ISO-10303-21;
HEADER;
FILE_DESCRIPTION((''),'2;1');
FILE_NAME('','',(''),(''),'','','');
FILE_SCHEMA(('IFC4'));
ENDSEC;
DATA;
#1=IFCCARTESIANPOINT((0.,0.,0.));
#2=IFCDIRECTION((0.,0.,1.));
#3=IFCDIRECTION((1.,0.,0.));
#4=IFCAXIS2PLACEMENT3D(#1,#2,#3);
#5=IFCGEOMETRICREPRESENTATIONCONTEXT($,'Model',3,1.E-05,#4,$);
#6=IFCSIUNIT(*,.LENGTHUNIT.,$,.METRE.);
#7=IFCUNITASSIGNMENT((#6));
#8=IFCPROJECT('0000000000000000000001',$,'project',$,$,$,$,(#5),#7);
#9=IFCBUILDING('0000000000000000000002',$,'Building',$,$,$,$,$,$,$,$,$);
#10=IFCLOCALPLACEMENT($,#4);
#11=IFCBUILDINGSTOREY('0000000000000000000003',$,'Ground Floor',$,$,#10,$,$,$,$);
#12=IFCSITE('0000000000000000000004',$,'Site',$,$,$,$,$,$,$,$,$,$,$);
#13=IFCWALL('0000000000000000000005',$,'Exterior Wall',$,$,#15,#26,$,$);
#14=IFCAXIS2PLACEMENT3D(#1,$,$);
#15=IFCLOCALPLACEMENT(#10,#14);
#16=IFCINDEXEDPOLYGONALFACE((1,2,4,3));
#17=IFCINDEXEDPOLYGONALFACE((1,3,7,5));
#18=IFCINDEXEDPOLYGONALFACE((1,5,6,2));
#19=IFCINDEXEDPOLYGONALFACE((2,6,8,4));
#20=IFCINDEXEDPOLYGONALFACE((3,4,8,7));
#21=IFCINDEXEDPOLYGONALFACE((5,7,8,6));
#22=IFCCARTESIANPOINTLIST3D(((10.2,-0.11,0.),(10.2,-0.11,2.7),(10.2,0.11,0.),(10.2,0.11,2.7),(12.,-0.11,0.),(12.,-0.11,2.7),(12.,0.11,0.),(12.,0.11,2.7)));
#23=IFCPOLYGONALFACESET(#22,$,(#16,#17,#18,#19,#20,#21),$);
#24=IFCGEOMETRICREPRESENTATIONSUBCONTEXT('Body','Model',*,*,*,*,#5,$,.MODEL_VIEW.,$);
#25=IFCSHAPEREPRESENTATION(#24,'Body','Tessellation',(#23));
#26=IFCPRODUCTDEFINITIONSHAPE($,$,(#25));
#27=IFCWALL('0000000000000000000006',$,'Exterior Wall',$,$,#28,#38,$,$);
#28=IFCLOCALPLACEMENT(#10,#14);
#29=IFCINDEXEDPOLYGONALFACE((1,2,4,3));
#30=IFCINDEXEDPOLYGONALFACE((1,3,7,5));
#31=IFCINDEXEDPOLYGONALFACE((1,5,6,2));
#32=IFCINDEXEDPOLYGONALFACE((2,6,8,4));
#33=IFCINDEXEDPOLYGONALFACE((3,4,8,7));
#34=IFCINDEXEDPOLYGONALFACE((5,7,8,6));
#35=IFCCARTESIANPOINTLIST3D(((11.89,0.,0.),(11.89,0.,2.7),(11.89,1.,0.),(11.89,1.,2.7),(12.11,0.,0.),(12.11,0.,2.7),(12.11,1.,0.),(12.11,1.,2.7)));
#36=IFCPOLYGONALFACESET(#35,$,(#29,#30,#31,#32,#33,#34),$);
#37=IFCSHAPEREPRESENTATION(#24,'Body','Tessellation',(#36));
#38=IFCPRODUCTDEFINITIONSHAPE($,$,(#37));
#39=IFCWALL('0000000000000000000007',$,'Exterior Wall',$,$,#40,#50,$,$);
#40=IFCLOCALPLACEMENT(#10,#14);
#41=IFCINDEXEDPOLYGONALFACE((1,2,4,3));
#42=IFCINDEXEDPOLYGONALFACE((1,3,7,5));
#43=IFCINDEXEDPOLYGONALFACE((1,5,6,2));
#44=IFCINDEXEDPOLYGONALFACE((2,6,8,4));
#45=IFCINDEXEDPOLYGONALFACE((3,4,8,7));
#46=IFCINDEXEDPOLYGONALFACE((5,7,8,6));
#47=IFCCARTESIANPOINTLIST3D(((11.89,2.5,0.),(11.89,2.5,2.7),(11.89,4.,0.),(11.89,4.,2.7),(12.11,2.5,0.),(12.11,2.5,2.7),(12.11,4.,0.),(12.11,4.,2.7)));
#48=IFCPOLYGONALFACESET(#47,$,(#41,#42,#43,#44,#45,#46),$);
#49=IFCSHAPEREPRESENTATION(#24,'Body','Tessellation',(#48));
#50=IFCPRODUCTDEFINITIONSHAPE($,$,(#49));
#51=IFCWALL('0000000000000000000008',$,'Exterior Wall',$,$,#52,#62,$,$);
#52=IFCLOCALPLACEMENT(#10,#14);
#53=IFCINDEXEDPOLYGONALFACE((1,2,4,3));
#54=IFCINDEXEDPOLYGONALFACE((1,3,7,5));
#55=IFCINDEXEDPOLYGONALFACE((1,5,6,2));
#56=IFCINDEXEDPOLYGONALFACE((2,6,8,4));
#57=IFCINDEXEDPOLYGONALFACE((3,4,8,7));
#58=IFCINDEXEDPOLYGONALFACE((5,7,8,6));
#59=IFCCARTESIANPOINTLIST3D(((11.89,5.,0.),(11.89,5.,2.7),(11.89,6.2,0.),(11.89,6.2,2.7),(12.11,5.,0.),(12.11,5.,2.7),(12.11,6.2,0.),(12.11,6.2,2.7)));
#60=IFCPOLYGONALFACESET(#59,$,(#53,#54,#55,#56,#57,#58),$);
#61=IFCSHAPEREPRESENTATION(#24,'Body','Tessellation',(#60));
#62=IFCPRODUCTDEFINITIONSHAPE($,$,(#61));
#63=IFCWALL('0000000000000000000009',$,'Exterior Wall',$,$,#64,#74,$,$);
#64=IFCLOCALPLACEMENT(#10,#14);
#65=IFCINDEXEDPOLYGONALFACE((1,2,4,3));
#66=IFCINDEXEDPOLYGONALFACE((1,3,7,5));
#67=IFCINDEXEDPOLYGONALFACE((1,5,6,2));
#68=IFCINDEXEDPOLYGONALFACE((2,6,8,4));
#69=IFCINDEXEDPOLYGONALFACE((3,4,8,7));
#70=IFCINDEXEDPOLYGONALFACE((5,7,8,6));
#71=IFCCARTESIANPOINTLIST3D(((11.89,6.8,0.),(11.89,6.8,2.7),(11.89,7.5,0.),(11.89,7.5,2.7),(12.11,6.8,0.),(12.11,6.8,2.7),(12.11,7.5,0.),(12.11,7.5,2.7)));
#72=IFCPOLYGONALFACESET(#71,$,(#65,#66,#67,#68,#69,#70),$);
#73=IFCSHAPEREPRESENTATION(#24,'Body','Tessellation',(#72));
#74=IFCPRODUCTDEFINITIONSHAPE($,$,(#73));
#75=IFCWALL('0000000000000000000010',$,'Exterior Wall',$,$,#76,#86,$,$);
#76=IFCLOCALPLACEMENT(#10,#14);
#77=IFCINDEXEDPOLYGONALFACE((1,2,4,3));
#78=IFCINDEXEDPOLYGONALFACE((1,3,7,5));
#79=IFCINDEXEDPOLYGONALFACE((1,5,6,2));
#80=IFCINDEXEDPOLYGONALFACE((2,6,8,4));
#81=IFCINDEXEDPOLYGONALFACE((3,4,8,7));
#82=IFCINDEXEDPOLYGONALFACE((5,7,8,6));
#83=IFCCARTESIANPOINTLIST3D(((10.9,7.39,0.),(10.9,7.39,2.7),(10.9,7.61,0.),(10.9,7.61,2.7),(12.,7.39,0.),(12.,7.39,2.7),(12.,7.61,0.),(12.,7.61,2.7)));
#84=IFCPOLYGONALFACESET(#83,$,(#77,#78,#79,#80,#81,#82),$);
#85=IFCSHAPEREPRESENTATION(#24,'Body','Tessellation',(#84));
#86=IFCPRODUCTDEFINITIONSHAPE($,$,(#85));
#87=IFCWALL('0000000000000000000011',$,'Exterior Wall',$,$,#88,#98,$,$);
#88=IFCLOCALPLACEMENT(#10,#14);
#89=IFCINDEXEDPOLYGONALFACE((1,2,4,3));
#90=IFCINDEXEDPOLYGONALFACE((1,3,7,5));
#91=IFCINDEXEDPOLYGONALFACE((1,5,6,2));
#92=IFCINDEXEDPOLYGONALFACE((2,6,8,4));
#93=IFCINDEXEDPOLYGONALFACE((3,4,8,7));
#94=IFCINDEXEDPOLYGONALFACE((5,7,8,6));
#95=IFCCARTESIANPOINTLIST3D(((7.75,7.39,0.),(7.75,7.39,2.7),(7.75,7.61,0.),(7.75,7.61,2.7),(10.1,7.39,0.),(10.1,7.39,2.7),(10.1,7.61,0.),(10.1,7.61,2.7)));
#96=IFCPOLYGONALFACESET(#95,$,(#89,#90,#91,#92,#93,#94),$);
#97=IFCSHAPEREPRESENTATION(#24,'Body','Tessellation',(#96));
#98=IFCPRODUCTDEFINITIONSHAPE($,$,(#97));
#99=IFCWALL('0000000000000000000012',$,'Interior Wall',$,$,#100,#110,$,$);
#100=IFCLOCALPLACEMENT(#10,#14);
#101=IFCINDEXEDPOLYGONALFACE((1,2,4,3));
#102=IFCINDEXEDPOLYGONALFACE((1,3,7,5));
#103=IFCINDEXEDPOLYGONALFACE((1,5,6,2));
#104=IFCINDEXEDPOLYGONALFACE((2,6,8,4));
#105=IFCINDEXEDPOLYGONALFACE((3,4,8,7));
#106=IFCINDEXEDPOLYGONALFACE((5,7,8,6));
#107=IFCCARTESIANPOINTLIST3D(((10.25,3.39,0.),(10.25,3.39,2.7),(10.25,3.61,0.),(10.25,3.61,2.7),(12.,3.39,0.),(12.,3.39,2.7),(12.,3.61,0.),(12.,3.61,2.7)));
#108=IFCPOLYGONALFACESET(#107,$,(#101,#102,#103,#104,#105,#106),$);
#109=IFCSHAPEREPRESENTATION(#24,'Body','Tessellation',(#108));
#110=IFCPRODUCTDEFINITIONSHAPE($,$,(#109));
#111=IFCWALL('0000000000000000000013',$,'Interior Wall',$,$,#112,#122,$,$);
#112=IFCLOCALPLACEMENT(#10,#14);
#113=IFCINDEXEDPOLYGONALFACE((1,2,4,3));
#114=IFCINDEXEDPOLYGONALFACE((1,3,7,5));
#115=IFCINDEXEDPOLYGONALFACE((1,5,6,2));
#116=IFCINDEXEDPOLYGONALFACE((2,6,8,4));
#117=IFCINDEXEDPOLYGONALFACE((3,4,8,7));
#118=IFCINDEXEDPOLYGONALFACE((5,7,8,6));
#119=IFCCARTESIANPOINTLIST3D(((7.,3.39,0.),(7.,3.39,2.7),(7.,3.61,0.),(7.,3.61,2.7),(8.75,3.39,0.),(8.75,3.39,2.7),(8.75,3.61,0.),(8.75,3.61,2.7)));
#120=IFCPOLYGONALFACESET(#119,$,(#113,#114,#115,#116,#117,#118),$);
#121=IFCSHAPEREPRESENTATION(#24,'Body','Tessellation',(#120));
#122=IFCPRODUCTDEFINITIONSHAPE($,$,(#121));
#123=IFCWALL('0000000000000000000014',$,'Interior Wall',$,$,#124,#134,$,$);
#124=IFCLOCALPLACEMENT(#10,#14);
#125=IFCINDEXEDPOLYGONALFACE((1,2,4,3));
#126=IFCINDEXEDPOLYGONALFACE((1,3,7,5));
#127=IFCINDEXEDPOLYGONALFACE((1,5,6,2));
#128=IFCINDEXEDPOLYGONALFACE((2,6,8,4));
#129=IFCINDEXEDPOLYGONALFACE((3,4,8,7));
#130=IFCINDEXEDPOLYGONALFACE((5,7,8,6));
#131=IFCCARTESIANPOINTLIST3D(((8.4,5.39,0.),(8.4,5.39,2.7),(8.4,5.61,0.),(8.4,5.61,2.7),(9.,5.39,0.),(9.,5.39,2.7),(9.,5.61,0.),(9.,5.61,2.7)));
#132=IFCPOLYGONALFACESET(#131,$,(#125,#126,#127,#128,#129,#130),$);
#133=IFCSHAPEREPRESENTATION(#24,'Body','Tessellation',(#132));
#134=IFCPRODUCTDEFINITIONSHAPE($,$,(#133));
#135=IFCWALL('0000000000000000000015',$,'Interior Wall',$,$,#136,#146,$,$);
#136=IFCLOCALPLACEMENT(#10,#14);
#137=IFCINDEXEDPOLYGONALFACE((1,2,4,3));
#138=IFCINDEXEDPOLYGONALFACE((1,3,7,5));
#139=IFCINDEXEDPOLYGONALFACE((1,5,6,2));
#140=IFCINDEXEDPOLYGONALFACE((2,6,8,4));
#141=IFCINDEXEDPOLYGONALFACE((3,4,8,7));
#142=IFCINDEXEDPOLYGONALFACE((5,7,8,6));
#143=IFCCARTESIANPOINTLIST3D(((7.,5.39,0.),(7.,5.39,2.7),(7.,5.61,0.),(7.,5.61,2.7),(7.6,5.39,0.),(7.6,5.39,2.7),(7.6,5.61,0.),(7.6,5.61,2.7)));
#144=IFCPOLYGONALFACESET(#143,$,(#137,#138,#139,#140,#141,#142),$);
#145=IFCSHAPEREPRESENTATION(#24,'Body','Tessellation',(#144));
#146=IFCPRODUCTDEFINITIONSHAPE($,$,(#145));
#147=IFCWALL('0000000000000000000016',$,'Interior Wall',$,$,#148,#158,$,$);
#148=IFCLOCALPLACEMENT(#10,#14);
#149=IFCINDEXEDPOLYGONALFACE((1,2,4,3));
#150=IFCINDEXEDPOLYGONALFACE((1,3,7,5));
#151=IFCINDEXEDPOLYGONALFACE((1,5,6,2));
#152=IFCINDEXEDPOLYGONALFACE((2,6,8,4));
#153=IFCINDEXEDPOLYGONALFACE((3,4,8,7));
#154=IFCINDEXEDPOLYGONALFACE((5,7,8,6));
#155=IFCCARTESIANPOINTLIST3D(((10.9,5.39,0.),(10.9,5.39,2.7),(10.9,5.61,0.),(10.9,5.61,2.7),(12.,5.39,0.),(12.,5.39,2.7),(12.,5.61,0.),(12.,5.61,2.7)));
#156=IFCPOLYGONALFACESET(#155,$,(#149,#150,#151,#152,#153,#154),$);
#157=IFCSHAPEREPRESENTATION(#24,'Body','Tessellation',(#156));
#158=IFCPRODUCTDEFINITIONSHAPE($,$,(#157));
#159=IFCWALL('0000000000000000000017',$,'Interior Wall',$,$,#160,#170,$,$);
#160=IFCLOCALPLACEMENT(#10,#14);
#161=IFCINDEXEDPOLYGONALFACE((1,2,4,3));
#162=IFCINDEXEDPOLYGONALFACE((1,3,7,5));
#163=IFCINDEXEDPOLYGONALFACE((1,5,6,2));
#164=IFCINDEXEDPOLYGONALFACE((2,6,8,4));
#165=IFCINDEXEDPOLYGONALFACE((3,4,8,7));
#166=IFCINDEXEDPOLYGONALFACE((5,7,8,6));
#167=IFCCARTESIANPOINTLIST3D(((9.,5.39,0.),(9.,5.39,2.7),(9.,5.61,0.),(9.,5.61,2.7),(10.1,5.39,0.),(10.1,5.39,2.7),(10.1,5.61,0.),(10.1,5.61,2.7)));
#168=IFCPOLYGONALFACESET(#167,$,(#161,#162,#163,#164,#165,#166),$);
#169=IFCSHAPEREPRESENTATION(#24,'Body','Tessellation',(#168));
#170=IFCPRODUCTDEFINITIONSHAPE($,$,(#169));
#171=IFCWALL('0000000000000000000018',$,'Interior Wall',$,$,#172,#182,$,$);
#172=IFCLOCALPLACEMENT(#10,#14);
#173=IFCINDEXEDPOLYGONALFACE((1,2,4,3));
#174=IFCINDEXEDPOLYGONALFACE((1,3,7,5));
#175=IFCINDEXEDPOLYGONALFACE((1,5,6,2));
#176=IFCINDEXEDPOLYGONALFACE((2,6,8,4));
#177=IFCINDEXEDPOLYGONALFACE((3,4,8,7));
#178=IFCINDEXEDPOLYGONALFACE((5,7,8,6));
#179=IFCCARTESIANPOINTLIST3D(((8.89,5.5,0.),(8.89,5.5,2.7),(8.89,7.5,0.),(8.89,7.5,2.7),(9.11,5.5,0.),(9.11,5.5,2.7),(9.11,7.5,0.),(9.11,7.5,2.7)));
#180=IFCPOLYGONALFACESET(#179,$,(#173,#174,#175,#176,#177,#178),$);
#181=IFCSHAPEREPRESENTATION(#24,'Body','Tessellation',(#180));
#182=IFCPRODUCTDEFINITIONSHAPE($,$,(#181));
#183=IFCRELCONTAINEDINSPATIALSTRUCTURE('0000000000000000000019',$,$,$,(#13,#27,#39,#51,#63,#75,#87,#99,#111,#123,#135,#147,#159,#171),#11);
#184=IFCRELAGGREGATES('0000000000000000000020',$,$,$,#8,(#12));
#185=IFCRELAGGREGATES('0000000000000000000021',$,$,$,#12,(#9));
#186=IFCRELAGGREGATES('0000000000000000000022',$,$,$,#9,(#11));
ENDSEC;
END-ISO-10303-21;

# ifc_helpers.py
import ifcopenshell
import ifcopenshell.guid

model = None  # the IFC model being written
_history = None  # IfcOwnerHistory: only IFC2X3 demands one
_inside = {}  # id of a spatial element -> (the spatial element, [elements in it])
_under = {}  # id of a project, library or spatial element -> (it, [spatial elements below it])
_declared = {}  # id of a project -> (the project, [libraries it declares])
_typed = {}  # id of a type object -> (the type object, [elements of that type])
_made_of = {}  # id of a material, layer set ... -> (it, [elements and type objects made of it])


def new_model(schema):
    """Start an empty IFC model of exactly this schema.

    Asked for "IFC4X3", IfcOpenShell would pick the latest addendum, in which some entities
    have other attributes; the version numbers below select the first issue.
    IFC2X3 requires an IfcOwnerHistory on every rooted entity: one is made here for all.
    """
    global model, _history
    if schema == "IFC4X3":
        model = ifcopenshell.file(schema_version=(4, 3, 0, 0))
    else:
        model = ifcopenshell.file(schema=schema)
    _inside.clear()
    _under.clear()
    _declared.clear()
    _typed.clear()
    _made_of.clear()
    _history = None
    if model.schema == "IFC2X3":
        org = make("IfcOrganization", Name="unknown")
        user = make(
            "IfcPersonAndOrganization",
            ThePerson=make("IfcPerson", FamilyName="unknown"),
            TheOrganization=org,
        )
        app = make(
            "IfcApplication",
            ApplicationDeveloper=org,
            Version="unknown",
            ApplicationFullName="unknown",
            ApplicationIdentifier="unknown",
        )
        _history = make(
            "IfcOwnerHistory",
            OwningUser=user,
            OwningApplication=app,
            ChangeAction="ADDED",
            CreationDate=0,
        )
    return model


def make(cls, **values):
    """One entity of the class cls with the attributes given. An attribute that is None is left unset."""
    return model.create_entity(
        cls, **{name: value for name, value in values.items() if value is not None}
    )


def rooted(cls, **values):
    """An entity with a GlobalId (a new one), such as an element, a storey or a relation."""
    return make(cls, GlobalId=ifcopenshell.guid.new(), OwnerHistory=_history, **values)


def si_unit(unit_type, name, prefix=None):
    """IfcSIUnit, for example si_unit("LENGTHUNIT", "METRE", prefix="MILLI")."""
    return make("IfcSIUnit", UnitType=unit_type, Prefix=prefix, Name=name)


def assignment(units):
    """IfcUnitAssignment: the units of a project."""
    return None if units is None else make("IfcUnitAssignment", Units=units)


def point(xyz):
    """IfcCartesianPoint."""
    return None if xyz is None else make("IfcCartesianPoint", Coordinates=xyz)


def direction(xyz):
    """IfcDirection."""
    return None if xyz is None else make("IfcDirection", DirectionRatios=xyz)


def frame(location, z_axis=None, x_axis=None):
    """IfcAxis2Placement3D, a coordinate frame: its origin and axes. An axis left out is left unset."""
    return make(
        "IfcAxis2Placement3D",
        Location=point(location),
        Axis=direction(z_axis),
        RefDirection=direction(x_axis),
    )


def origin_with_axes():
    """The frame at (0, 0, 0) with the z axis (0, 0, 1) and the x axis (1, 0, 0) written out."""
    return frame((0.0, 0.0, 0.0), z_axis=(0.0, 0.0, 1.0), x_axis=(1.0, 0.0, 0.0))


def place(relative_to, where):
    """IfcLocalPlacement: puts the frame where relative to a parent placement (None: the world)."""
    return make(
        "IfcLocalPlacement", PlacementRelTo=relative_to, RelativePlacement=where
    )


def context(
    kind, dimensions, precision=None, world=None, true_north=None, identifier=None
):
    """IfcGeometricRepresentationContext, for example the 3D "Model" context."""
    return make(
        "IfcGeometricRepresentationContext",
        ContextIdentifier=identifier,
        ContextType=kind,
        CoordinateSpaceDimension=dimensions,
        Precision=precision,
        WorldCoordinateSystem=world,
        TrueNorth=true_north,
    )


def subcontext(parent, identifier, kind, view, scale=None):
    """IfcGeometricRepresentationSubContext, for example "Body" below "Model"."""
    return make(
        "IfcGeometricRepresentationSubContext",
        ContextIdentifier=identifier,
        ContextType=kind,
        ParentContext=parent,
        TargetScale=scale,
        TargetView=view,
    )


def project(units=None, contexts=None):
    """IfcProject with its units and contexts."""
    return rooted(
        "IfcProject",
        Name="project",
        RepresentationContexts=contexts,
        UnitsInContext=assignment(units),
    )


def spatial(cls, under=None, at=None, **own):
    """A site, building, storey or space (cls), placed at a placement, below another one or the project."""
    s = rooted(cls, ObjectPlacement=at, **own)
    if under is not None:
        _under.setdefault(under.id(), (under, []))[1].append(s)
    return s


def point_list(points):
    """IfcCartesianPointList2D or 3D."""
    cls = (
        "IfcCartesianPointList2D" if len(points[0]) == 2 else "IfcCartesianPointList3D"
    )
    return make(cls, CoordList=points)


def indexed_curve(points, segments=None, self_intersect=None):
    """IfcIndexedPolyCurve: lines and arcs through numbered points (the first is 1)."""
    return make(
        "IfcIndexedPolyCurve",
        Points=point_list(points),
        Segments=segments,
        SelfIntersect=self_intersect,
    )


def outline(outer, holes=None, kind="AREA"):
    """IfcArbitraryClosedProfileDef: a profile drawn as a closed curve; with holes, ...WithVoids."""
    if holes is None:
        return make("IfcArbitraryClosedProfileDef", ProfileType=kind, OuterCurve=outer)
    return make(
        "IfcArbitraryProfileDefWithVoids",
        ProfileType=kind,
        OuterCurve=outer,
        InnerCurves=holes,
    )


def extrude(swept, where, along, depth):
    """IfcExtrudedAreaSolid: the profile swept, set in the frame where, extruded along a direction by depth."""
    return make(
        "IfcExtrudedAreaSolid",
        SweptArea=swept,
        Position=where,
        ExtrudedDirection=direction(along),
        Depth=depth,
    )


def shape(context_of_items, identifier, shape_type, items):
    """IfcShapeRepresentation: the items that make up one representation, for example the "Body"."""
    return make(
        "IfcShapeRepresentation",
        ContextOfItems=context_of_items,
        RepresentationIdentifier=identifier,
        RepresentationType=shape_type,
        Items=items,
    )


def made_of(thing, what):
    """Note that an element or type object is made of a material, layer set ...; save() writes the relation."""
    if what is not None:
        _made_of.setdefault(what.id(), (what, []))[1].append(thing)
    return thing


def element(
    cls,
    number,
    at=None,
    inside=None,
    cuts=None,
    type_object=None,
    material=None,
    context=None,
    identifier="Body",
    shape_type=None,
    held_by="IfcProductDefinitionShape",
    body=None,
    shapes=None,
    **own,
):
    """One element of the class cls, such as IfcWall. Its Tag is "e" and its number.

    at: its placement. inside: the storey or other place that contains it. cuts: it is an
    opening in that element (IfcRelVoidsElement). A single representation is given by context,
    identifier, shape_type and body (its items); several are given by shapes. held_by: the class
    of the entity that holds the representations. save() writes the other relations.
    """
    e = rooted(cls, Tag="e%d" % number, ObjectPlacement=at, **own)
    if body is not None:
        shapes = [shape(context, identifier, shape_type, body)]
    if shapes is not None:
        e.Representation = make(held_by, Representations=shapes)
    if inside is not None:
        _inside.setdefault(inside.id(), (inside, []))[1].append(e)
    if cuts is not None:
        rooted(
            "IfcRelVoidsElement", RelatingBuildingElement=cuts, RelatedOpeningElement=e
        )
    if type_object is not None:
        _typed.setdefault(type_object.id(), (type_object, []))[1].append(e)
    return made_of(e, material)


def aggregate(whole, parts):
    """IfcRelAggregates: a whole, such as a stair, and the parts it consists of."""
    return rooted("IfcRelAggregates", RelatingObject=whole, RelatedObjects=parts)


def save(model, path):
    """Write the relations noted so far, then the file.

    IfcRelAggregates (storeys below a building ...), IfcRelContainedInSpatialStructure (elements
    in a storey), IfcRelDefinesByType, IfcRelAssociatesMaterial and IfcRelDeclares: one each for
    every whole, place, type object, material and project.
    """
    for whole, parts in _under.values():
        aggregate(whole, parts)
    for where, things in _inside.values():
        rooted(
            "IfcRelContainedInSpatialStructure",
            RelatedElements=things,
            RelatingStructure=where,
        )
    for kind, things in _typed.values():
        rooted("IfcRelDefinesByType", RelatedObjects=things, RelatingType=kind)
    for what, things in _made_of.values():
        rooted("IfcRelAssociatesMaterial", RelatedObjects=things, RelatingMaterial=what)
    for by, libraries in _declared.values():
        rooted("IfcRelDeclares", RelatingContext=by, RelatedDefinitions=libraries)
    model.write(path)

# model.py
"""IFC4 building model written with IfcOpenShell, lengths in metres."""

from ifc_helpers import new_model, si_unit, frame, origin_with_axes, place, context, subcontext, project, spatial, indexed_curve, outline, extrude, element, save


model = new_model("IFC4")

# Units and contexts
model_context = context("Model", 3, precision=1e-05, world=origin_with_axes())
body_context = subcontext(model_context, "Body", "Model", "MODEL_VIEW")
ifc_project = project(units=[si_unit("LENGTHUNIT", "METRE")], contexts=[model_context])

# Site, building, storey
site = spatial("IfcSite", under=ifc_project, Name="Site")
building = spatial("IfcBuilding", under=site, Name="Building")
storey_placement = place(None, origin_with_axes())
storey = spatial("IfcBuildingStorey", under=building, at=storey_placement, Name="Ground Floor")

# Walls
wall_1_placement = place(storey_placement, frame((10.2, 0.0, 0.0), z_axis=(0.0, 0.0, 1.0), x_axis=(1.0, 0.0, 0.0)))
element("IfcWall", 1, at=wall_1_placement, inside=storey, Name="Exterior Wall", context=body_context, shape_type="SweptSolid", body=[
    extrude(outline(indexed_curve([(0.0, 0.0), (0.0, 0.22), (1.8, 0.22), (1.8, 0.0), (0.0, 0.0)], self_intersect=False)), frame((0.0, -0.11, 0.0), z_axis=(0.0, 0.0, 1.0), x_axis=(1.0, 0.0, 0.0)), (0.0, 0.0, 1.0), 2.7),
])
wall_2_placement = place(storey_placement, frame((12.0, 0.0, 0.0), z_axis=(0.0, 0.0, 1.0), x_axis=(0.0, 1.0, 0.0)))
element("IfcWall", 2, at=wall_2_placement, inside=storey, Name="Exterior Wall", context=body_context, shape_type="SweptSolid", body=[
    extrude(outline(indexed_curve([(0.0, 0.0), (0.0, 0.22), (1.0, 0.22), (1.0, 0.0), (0.0, 0.0)], self_intersect=False)), frame((0.0, -0.11, 0.0), z_axis=(0.0, 0.0, 1.0), x_axis=(1.0, 0.0, 0.0)), (0.0, 0.0, 1.0), 2.7),
])
wall_3_placement = place(storey_placement, frame((12.0, 2.5, 0.0), z_axis=(0.0, 0.0, 1.0), x_axis=(0.0, 1.0, 0.0)))
element("IfcWall", 3, at=wall_3_placement, inside=storey, Name="Exterior Wall", context=body_context, shape_type="SweptSolid", body=[
    extrude(outline(indexed_curve([(0.0, 0.0), (0.0, 0.22), (1.5, 0.22), (1.5, 0.0), (0.0, 0.0)], self_intersect=False)), frame((0.0, -0.11, 0.0), z_axis=(0.0, 0.0, 1.0), x_axis=(1.0, 0.0, 0.0)), (0.0, 0.0, 1.0), 2.7),
])
wall_4_placement = place(storey_placement, frame((12.0, 5.0, 0.0), z_axis=(0.0, 0.0, 1.0), x_axis=(0.0, 1.0, 0.0)))
element("IfcWall", 4, at=wall_4_placement, inside=storey, Name="Exterior Wall", context=body_context, shape_type="SweptSolid", body=[
    extrude(outline(indexed_curve([(0.0, 0.0), (0.0, 0.22), (1.2, 0.22), (1.2, 0.0), (0.0, 0.0)], self_intersect=False)), frame((0.0, -0.11, 0.0), z_axis=(0.0, 0.0, 1.0), x_axis=(1.0, 0.0, 0.0)), (0.0, 0.0, 1.0), 2.7),
])
wall_5_placement = place(storey_placement, frame((12.0, 6.8, 0.0), z_axis=(0.0, 0.0, 1.0), x_axis=(0.0, 1.0, 0.0)))
element("IfcWall", 5, at=wall_5_placement, inside=storey, Name="Exterior Wall", context=body_context, shape_type="SweptSolid", body=[
    extrude(outline(indexed_curve([(0.0, 0.0), (0.0, 0.22), (0.7, 0.22), (0.7, 0.0), (0.0, 0.0)], self_intersect=False)), frame((0.0, -0.11, 0.0), z_axis=(0.0, 0.0, 1.0), x_axis=(1.0, 0.0, 0.0)), (0.0, 0.0, 1.0), 2.7),
])
wall_6_placement = place(storey_placement, frame((12.0, 7.5, 0.0), z_axis=(0.0, 0.0, 1.0), x_axis=(-1.0, 0.0, 0.0)))
element("IfcWall", 6, at=wall_6_placement, inside=storey, Name="Exterior Wall", context=body_context, shape_type="SweptSolid", body=[
    extrude(outline(indexed_curve([(0.0, 0.0), (0.0, 0.22), (1.1, 0.22), (1.1, 0.0), (0.0, 0.0)], self_intersect=False)), frame((0.0, -0.11, 0.0), z_axis=(0.0, 0.0, 1.0), x_axis=(1.0, 0.0, 0.0)), (0.0, 0.0, 1.0), 2.7),
])
wall_7_placement = place(storey_placement, frame((10.1, 7.5, 0.0), z_axis=(0.0, 0.0, 1.0), x_axis=(-1.0, 0.0, 0.0)))
element("IfcWall", 7, at=wall_7_placement, inside=storey, Name="Exterior Wall", context=body_context, shape_type="SweptSolid", body=[
    extrude(outline(indexed_curve([(0.0, 0.0), (0.0, 0.22), (2.35, 0.22), (2.35, 0.0), (0.0, 0.0)], self_intersect=False)), frame((0.0, -0.11, 0.0), z_axis=(0.0, 0.0, 1.0), x_axis=(1.0, 0.0, 0.0)), (0.0, 0.0, 1.0), 2.7),
])
for number, where, z_axis, x_axis, name in (
    (8, (12.0, 3.5, 0.0), (0.0, 0.0, 1.0), (-1.0, 0.0, 0.0), "Interior Wall"),
    (9, (8.75, 3.5, 0.0), (0.0, 0.0, 1.0), (-1.0, 0.0, 0.0), "Interior Wall"),
):
    element("IfcWall", number, at=place(storey_placement, frame(where, z_axis=z_axis, x_axis=x_axis)), inside=storey, Name=name, context=body_context, shape_type="SweptSolid", body=[
        extrude(outline(indexed_curve([(0.0, 0.0), (0.0, 0.22), (1.75, 0.22), (1.75, 0.0), (0.0, 0.0)], self_intersect=False)), frame((0.0, -0.11, 0.0), z_axis=(0.0, 0.0, 1.0), x_axis=(1.0, 0.0, 0.0)), (0.0, 0.0, 1.0), 2.7),
    ])
for number, where, z_axis, x_axis, name in (
    (10, (9.0, 5.5, 0.0), (0.0, 0.0, 1.0), (-1.0, 0.0, 0.0), "Interior Wall"),
    (11, (7.6, 5.5, 0.0), (0.0, 0.0, 1.0), (-1.0, 0.0, 0.0), "Interior Wall"),
):
    element("IfcWall", number, at=place(storey_placement, frame(where, z_axis=z_axis, x_axis=x_axis)), inside=storey, Name=name, context=body_context, shape_type="SweptSolid", body=[
        extrude(outline(indexed_curve([(0.0, 0.0), (0.0, 0.22), (0.6, 0.22), (0.6, 0.0), (0.0, 0.0)], self_intersect=False)), frame((0.0, -0.11, 0.0), z_axis=(0.0, 0.0, 1.0), x_axis=(1.0, 0.0, 0.0)), (0.0, 0.0, 1.0), 2.7),
    ])
for number, where, z_axis, x_axis, name in (
    (12, (12.0, 5.5, 0.0), (0.0, 0.0, 1.0), (-1.0, 0.0, 0.0), "Interior Wall"),
    (13, (10.1, 5.5, 0.0), (0.0, 0.0, 1.0), (-1.0, 0.0, 0.0), "Interior Wall"),
):
    element("IfcWall", number, at=place(storey_placement, frame(where, z_axis=z_axis, x_axis=x_axis)), inside=storey, Name=name, context=body_context, shape_type="SweptSolid", body=[
        extrude(outline(indexed_curve([(0.0, 0.0), (0.0, 0.22), (1.1, 0.22), (1.1, 0.0), (0.0, 0.0)], self_intersect=False)), frame((0.0, -0.11, 0.0), z_axis=(0.0, 0.0, 1.0), x_axis=(1.0, 0.0, 0.0)), (0.0, 0.0, 1.0), 2.7),
    ])
wall_8_placement = place(storey_placement, frame((9.0, 5.5, 0.0), z_axis=(0.0, 0.0, 1.0), x_axis=(0.0, 1.0, 0.0)))
element("IfcWall", 14, at=wall_8_placement, inside=storey, Name="Interior Wall", context=body_context, shape_type="SweptSolid", body=[
    extrude(outline(indexed_curve([(0.0, 0.0), (0.0, 0.22), (2.0, 0.22), (2.0, 0.0), (0.0, 0.0)], self_intersect=False)), frame((0.0, -0.11, 0.0), z_axis=(0.0, 0.0, 1.0), x_axis=(1.0, 0.0, 0.0)), (0.0, 0.0, 1.0), 2.7),
])

save(model, "model.ifc")
